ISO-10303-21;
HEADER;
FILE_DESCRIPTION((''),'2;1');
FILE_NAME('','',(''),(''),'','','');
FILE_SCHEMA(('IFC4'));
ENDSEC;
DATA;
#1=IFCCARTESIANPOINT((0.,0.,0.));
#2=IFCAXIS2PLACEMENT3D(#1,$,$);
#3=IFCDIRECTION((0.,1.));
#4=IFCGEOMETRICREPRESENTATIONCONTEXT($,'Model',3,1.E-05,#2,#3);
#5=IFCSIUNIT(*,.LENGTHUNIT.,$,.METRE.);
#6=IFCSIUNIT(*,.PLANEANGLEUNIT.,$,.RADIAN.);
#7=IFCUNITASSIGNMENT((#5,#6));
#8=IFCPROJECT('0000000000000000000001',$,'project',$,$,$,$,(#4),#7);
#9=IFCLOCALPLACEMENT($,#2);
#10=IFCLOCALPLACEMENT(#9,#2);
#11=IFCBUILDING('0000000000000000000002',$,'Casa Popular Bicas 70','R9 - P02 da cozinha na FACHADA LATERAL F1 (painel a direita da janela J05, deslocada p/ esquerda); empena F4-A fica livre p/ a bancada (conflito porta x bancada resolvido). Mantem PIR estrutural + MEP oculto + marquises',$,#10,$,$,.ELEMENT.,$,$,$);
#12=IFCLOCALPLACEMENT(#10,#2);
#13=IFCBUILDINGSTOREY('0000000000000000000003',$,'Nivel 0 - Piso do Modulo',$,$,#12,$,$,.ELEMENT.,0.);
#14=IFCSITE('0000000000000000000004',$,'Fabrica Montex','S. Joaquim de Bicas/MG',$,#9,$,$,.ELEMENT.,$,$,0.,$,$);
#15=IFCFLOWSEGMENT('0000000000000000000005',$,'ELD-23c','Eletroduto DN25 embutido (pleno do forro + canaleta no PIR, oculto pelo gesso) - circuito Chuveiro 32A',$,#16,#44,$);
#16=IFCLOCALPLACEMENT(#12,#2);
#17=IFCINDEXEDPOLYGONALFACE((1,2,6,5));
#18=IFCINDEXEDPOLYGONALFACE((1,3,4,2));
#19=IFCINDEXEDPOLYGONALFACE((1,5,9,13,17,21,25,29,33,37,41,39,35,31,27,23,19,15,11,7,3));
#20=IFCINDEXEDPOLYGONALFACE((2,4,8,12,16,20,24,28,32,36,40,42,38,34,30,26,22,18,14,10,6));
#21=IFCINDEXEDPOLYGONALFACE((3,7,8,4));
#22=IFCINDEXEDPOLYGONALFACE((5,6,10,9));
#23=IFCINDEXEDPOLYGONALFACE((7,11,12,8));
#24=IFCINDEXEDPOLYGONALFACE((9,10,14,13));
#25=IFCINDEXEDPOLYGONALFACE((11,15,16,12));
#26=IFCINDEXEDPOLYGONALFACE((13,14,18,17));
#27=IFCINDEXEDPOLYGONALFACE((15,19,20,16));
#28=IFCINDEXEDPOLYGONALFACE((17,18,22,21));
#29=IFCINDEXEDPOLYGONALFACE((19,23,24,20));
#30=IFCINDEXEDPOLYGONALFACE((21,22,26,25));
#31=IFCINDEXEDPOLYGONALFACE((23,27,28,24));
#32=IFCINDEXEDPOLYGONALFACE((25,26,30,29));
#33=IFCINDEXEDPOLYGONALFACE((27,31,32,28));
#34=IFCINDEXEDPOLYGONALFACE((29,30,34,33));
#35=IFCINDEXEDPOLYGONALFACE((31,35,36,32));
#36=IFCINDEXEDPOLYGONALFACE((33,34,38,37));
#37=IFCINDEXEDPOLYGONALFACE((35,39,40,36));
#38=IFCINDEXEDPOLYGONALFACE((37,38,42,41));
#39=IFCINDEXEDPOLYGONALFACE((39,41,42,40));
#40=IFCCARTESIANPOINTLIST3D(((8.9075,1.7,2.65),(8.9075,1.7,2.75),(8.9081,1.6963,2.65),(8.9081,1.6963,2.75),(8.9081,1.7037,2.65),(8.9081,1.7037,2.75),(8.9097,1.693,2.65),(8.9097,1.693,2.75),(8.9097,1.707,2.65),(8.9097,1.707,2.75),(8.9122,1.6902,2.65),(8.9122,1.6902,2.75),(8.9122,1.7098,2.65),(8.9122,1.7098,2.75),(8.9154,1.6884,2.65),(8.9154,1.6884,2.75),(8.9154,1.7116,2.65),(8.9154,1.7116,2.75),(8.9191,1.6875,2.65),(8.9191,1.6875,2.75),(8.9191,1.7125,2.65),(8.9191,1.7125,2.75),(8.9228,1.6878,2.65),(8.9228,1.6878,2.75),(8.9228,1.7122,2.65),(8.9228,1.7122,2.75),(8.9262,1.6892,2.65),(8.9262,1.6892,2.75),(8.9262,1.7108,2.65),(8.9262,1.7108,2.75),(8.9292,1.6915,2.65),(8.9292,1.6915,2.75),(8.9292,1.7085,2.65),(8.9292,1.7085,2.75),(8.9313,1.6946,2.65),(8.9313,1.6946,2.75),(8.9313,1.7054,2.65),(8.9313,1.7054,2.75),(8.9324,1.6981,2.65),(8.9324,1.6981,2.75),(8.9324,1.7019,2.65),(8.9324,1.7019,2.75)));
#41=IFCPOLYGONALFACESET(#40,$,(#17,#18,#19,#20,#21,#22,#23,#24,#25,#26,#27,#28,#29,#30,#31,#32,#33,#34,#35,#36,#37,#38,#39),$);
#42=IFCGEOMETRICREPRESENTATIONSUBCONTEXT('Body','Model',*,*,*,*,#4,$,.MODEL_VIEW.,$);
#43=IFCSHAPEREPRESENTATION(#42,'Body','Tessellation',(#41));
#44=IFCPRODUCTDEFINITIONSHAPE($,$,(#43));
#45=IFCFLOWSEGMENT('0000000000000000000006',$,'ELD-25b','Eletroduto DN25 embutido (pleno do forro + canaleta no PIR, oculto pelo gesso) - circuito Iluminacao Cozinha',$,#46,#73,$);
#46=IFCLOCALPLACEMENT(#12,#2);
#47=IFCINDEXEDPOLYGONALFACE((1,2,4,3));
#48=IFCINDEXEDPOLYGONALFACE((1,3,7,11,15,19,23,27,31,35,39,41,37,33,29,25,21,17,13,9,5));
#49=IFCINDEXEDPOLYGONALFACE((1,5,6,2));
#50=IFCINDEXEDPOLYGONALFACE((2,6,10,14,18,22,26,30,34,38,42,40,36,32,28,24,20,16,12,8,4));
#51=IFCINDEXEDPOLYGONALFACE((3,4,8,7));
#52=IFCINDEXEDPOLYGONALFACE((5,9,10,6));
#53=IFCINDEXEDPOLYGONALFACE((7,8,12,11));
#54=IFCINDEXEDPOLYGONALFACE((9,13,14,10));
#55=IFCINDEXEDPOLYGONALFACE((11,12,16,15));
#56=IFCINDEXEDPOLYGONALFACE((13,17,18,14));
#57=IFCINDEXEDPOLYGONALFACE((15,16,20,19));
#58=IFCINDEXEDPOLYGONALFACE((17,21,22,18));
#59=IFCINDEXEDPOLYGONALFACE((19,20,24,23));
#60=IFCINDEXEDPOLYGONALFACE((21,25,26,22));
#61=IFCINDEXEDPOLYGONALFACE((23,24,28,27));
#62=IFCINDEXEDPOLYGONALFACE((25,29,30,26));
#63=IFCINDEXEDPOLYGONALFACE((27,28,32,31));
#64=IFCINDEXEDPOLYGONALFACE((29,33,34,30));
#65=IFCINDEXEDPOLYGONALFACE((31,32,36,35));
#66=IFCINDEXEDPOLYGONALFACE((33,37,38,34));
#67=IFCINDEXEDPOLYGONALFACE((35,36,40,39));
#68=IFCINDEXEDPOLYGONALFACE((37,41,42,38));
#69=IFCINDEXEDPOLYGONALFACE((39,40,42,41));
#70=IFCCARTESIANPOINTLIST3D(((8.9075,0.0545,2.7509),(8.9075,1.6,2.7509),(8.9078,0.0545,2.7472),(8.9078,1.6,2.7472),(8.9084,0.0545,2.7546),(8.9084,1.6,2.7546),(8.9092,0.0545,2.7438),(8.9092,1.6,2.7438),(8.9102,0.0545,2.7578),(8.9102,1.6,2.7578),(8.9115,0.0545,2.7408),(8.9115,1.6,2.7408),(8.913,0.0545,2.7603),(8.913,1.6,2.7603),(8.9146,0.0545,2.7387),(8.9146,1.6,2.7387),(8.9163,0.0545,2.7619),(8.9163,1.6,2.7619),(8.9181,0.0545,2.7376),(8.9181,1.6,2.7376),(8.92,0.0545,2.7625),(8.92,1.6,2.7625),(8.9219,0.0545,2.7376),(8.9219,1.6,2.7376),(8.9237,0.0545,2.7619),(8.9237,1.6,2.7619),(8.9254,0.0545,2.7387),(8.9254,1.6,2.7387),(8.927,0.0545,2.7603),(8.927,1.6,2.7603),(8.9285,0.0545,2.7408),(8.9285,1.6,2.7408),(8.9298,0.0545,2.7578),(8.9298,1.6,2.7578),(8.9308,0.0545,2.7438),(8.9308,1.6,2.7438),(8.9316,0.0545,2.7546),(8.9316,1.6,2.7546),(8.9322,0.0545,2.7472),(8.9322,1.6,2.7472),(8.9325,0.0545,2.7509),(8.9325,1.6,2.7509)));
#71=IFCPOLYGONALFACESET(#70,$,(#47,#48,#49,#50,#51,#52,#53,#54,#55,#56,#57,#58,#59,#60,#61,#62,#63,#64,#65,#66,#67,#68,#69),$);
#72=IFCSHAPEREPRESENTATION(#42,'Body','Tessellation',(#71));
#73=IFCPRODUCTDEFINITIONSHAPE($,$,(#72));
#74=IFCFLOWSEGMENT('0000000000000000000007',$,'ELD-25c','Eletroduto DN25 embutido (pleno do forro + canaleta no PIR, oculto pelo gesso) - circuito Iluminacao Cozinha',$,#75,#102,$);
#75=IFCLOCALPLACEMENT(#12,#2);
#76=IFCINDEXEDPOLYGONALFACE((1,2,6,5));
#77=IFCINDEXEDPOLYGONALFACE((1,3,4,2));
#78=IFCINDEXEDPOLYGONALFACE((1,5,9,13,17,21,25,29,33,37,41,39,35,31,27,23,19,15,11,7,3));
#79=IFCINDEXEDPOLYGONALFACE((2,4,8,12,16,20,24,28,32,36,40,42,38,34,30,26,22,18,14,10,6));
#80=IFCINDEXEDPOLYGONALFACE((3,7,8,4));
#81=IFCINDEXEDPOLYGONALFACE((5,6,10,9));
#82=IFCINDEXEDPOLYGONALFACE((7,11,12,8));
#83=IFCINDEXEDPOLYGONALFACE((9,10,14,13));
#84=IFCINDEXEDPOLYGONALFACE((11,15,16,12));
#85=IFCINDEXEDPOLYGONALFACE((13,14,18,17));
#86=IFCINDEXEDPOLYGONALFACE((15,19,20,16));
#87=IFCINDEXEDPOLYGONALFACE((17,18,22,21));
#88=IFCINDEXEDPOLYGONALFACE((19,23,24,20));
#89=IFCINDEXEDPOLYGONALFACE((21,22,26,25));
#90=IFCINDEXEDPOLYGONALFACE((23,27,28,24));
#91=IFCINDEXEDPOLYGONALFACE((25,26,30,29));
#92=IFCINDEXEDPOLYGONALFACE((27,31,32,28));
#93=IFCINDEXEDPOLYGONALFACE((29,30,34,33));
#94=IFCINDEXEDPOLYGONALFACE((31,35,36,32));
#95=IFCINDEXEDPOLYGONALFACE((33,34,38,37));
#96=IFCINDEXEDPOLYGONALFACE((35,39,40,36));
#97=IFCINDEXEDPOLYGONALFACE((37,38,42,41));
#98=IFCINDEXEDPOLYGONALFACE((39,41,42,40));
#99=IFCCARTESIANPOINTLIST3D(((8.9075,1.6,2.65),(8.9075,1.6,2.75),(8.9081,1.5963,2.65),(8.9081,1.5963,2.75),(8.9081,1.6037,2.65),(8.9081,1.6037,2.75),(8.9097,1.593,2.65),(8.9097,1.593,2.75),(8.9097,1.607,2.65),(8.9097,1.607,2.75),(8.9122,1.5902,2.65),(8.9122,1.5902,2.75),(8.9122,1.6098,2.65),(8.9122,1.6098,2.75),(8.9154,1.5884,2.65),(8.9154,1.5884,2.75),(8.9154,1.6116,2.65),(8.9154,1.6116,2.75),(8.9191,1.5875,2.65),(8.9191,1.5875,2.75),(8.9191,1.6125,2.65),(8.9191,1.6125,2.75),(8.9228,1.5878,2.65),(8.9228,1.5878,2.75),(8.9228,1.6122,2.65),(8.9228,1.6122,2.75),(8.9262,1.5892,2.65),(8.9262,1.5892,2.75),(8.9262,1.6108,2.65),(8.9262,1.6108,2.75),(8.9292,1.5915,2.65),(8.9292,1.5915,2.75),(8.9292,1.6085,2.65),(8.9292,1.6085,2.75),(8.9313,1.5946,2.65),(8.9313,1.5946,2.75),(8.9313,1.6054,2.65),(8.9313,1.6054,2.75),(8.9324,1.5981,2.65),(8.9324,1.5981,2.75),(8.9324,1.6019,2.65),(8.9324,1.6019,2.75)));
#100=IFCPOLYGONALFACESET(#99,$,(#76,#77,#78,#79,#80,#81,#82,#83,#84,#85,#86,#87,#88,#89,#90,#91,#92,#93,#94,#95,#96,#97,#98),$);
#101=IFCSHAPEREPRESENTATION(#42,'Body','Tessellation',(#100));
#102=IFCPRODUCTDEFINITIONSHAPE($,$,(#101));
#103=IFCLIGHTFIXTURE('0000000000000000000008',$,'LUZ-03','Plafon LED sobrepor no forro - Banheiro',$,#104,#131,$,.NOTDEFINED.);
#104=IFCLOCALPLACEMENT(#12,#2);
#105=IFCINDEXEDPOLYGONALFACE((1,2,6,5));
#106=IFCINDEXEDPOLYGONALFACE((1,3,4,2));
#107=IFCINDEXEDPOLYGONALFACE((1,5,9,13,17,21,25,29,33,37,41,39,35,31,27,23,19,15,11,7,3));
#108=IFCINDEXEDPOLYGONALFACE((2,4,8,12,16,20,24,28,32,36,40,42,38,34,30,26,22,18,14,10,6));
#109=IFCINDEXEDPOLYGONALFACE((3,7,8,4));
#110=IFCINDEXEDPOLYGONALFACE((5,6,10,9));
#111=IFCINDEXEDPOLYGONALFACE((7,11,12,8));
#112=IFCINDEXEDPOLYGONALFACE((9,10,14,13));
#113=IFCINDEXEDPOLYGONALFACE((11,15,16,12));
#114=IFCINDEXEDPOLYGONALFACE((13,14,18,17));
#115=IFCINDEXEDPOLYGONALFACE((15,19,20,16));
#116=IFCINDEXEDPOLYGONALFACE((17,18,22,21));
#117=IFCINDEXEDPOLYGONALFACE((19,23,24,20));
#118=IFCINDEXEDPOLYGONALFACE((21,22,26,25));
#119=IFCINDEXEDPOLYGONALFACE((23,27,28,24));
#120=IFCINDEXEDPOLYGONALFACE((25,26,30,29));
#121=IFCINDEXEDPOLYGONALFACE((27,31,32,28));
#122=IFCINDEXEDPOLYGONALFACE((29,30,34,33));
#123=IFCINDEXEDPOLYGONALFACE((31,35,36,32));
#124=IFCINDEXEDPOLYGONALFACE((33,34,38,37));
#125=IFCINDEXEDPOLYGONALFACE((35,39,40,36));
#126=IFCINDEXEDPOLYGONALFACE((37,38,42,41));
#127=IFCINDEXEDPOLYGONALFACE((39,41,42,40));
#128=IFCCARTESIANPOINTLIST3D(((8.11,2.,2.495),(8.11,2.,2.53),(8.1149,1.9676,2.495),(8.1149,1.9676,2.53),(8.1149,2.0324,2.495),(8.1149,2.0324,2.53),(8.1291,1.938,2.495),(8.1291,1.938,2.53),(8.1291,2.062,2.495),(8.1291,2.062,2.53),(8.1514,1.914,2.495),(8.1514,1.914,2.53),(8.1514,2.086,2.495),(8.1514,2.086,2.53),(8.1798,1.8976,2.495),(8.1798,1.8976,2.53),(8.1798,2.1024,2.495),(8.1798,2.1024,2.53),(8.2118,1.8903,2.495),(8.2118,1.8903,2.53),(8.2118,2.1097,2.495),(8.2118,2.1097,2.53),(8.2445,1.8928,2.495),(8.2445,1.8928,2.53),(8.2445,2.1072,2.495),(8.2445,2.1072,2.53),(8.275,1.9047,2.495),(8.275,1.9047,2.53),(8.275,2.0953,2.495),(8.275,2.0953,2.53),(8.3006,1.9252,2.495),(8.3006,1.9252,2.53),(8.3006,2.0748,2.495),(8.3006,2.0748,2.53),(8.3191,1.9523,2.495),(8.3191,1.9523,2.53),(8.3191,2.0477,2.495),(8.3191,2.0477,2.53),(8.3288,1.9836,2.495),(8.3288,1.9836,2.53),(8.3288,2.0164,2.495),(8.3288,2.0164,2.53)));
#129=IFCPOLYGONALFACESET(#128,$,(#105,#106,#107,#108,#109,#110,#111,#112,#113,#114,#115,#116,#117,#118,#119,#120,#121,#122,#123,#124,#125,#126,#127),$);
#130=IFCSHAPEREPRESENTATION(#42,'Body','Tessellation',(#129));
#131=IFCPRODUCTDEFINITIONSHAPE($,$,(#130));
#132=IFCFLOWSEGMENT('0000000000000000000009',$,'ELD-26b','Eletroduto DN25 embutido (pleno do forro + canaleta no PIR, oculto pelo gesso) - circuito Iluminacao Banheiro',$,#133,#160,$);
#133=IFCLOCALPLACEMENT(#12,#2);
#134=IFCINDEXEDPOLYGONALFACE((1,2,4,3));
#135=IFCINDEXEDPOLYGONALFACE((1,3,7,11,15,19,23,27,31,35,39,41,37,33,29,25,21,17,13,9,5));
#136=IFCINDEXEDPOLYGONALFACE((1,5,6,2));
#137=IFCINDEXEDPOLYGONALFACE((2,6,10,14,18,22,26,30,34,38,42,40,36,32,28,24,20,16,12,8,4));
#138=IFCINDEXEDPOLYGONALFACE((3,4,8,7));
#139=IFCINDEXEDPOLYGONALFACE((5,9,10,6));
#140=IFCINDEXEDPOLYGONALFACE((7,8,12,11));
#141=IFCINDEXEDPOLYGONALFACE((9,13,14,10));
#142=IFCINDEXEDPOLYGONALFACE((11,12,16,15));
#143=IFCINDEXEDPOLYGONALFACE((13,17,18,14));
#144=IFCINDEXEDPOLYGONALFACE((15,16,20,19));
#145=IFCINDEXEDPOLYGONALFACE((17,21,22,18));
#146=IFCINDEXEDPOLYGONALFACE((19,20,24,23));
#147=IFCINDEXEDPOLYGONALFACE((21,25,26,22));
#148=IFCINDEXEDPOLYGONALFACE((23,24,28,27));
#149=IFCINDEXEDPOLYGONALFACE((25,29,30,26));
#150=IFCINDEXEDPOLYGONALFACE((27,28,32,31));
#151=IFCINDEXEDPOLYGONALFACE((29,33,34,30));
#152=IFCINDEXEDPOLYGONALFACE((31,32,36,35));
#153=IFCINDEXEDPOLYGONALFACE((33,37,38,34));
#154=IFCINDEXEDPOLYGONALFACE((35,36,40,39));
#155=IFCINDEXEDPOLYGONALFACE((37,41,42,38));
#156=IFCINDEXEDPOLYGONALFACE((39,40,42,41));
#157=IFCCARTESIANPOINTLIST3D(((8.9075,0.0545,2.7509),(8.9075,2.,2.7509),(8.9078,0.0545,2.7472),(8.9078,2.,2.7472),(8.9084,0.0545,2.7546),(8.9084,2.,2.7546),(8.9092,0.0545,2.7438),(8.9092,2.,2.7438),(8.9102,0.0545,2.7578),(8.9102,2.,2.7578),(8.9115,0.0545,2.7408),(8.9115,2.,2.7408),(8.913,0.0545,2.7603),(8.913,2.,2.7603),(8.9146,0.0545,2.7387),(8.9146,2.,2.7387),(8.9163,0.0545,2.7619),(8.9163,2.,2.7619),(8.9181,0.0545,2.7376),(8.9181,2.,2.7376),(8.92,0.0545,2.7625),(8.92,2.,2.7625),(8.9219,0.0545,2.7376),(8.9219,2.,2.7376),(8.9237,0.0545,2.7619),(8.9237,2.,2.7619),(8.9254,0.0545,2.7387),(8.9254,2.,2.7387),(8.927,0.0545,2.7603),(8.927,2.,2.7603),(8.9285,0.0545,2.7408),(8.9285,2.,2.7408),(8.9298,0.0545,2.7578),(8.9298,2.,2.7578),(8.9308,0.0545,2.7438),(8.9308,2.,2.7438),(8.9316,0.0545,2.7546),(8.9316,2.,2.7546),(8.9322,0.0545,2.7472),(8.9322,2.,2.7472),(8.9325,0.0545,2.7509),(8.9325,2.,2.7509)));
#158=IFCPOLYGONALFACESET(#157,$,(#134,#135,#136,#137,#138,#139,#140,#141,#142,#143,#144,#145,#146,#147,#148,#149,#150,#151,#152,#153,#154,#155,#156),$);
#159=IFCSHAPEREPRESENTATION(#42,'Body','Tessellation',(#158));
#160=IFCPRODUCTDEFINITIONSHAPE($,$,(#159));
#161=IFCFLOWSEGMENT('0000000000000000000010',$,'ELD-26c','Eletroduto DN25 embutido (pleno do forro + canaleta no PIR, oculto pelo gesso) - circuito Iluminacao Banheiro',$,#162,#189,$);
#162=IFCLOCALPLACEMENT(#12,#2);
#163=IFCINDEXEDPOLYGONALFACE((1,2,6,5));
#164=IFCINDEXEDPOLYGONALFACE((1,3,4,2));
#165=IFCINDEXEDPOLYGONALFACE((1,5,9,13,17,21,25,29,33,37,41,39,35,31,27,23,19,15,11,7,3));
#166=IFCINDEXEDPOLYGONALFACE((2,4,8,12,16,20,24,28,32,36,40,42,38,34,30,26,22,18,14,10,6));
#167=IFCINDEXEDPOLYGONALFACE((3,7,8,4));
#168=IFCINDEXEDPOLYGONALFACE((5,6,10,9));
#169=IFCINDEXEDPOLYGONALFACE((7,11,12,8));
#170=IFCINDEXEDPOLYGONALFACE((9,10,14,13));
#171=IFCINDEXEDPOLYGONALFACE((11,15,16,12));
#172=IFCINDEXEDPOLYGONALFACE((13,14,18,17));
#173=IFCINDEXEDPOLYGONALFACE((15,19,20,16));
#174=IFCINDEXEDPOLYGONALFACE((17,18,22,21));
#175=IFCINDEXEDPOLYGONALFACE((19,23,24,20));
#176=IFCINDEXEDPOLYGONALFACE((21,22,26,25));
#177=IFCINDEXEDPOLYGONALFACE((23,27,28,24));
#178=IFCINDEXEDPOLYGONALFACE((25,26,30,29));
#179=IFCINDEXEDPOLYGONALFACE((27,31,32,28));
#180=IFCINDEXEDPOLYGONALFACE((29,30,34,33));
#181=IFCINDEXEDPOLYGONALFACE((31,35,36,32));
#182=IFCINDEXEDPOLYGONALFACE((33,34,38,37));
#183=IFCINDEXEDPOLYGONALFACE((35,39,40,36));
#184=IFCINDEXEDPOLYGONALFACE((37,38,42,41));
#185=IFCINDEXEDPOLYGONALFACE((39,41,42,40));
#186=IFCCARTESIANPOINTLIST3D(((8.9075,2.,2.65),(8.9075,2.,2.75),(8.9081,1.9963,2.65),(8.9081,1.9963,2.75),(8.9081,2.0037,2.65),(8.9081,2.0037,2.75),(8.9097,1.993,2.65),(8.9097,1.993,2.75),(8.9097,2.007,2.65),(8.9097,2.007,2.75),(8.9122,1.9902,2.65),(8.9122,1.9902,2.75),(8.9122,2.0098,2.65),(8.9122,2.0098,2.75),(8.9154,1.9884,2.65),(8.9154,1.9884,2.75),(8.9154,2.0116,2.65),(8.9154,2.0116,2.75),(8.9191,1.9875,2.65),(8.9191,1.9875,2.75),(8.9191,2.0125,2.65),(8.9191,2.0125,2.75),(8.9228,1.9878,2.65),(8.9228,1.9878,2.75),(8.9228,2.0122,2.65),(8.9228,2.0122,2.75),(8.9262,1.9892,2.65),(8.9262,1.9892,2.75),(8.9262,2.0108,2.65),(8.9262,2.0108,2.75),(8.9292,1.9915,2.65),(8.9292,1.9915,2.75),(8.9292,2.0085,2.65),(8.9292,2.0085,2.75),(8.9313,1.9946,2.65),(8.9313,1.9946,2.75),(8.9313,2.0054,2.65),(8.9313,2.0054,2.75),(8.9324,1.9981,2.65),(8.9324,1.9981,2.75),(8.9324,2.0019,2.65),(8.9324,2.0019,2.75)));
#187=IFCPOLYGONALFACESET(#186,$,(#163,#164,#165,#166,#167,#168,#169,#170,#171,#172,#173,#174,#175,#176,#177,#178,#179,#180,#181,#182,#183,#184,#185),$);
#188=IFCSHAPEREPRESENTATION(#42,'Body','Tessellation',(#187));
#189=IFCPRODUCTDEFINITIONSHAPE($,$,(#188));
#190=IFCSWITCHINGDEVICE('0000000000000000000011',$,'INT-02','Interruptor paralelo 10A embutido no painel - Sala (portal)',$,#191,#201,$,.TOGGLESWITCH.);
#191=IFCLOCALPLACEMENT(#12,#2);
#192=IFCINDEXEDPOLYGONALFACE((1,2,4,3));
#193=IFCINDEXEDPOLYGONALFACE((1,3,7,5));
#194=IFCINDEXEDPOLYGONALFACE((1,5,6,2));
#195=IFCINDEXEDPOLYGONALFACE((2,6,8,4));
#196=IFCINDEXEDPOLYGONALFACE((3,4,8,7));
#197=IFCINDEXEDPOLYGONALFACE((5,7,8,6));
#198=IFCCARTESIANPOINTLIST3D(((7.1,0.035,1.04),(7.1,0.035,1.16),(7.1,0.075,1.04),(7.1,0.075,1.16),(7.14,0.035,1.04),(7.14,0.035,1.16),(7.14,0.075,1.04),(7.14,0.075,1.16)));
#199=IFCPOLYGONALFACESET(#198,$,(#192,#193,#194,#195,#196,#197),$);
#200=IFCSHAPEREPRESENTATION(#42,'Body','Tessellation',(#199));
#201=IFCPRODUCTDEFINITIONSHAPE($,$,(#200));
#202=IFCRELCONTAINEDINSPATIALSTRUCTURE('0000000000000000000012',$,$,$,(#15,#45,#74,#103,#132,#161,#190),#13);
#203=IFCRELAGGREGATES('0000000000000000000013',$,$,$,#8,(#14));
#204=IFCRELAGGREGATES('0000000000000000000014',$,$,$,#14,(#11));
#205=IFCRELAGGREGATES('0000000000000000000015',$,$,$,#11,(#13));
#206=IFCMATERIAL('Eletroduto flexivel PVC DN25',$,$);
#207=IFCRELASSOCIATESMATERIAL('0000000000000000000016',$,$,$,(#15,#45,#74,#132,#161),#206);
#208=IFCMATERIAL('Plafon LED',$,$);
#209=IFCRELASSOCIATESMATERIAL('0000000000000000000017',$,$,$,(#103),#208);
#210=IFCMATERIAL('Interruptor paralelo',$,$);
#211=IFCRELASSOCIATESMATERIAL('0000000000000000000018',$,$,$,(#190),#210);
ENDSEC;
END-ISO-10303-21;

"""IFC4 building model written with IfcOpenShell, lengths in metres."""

from ifc_helpers import new_model, si_unit, direction, frame, frame_2d, origin, origin_2d, place, context, subcontext, project, spatial, rectangle, circle, extrude, material, element, save


model = new_model("IFC4")

# Units and contexts
model_context = context("Model", 3, precision=1e-05, world=origin(), true_north=direction((0.0, 1.0)))
body_context = subcontext(model_context, "Body", "Model", "MODEL_VIEW")
ifc_project = project(units=[si_unit("LENGTHUNIT", "METRE"), si_unit("PLANEANGLEUNIT", "RADIAN")], contexts=[model_context])

# Site, building, storey
site_placement = place(None, origin())
site = spatial("IfcSite", under=ifc_project, at=site_placement, Name="Fabrica Montex", Description="S. Joaquim de Bicas/MG", CompositionType="ELEMENT", RefElevation=0.0)
building_placement = place(site_placement, origin())
building = spatial("IfcBuilding", under=site, at=building_placement, Name="Casa Popular Bicas 70", Description="R9 - P02 da cozinha na FACHADA LATERAL F1 (painel a direita da janela J05, deslocada p/ esquerda); empena F4-A fica livre p/ a bancada (conflito porta x bancada resolvido). Mantem PIR estrutural + MEP oculto + marquises", CompositionType="ELEMENT")
storey_placement = place(building_placement, origin())
storey = spatial("IfcBuildingStorey", under=building, at=storey_placement, Name="Nivel 0 - Piso do Modulo", CompositionType="ELEMENT", Elevation=0.0)

# Shared definitions
ifc_material_1 = material(Name="Eletroduto flexivel PVC DN25")

# Flow segments
flow_segment_1_placement = place(None, frame((8.92, 1.7, 2.75), z_axis=(0.0, 0.0, -1.0), x_axis=(-1.0, 0.0, 0.0)))
element("IfcFlowSegment", 1, at=flow_segment_1_placement, inside=storey, material=ifc_material_1, Name="ELD-23c", Description="Eletroduto DN25 embutido (pleno do forro + canaleta no PIR, oculto pelo gesso) - circuito Chuveiro 32A", context=body_context, shape_type="SweptSolid", body=[
    extrude(circle(Radius=0.0125, at=origin_2d()), origin(), (0.0, 0.0, 1.0), 0.1),
])
flow_segment_2_placement = place(None, frame((8.92, 0.0545, 2.75), z_axis=(0.0, 1.0, 0.0), x_axis=(0.0, 0.0, 1.0)))
element("IfcFlowSegment", 2, at=flow_segment_2_placement, inside=storey, material=ifc_material_1, Name="ELD-25b", Description="Eletroduto DN25 embutido (pleno do forro + canaleta no PIR, oculto pelo gesso) - circuito Iluminacao Cozinha", context=body_context, shape_type="SweptSolid", body=[
    extrude(circle(Radius=0.0125, at=origin_2d()), origin(), (0.0, 0.0, 1.0), 1.5455),
])
flow_segment_3_placement = place(None, frame((8.92, 1.6, 2.75), z_axis=(0.0, 0.0, -1.0), x_axis=(-1.0, 0.0, 0.0)))
element("IfcFlowSegment", 3, at=flow_segment_3_placement, inside=storey, material=ifc_material_1, Name="ELD-25c", Description="Eletroduto DN25 embutido (pleno do forro + canaleta no PIR, oculto pelo gesso) - circuito Iluminacao Cozinha", context=body_context, shape_type="SweptSolid", body=[
    extrude(circle(Radius=0.0125, at=origin_2d()), origin(), (0.0, 0.0, 1.0), 0.1),
])

# Light fixture
ifc_material_2 = material(Name="Plafon LED")
light_fixture_placement = place(None, frame((8.22, 2.0, 2.495), z_axis=(0.0, 0.0, 1.0), x_axis=(-1.0, 0.0, 0.0)))
element("IfcLightFixture", 4, at=light_fixture_placement, inside=storey, material=ifc_material_2, Name="LUZ-03", Description="Plafon LED sobrepor no forro - Banheiro", PredefinedType="NOTDEFINED", context=body_context, shape_type="SweptSolid", body=[
    extrude(circle(Radius=0.11, at=origin_2d()), origin(), (0.0, 0.0, 1.0), 0.035),
])

# Flow segments
flow_segment_4_placement = place(None, frame((8.92, 0.0545, 2.75), z_axis=(0.0, 1.0, 0.0), x_axis=(0.0, 0.0, 1.0)))
element("IfcFlowSegment", 5, at=flow_segment_4_placement, inside=storey, material=ifc_material_1, Name="ELD-26b", Description="Eletroduto DN25 embutido (pleno do forro + canaleta no PIR, oculto pelo gesso) - circuito Iluminacao Banheiro", context=body_context, shape_type="SweptSolid", body=[
    extrude(circle(Radius=0.0125, at=origin_2d()), origin(), (0.0, 0.0, 1.0), 1.9455),
])
flow_segment_5_placement = place(None, frame((8.92, 2.0, 2.75), z_axis=(0.0, 0.0, -1.0), x_axis=(-1.0, 0.0, 0.0)))
element("IfcFlowSegment", 6, at=flow_segment_5_placement, inside=storey, material=ifc_material_1, Name="ELD-26c", Description="Eletroduto DN25 embutido (pleno do forro + canaleta no PIR, oculto pelo gesso) - circuito Iluminacao Banheiro", context=body_context, shape_type="SweptSolid", body=[
    extrude(circle(Radius=0.0125, at=origin_2d()), origin(), (0.0, 0.0, 1.0), 0.1),
])

# Switching device
ifc_material_3 = material(Name="Interruptor paralelo")
switching_device_1_placement = place(None, frame((7.14, 0.075, 1.04), z_axis=(0.0, 0.0, 1.0), x_axis=(-1.0, 0.0, 0.0)))
element("IfcSwitchingDevice", 7, at=switching_device_1_placement, inside=storey, material=ifc_material_3, Name="INT-02", Description="Interruptor paralelo 10A embutido no painel - Sala (portal)", PredefinedType="TOGGLESWITCH", context=body_context, shape_type="SweptSolid", body=[
    extrude(rectangle(XDim=0.04, YDim=0.04, at=frame_2d((0.02, 0.02))), origin(), (0.0, 0.0, 1.0), 0.12),
])

save(model, "model.ifc")
